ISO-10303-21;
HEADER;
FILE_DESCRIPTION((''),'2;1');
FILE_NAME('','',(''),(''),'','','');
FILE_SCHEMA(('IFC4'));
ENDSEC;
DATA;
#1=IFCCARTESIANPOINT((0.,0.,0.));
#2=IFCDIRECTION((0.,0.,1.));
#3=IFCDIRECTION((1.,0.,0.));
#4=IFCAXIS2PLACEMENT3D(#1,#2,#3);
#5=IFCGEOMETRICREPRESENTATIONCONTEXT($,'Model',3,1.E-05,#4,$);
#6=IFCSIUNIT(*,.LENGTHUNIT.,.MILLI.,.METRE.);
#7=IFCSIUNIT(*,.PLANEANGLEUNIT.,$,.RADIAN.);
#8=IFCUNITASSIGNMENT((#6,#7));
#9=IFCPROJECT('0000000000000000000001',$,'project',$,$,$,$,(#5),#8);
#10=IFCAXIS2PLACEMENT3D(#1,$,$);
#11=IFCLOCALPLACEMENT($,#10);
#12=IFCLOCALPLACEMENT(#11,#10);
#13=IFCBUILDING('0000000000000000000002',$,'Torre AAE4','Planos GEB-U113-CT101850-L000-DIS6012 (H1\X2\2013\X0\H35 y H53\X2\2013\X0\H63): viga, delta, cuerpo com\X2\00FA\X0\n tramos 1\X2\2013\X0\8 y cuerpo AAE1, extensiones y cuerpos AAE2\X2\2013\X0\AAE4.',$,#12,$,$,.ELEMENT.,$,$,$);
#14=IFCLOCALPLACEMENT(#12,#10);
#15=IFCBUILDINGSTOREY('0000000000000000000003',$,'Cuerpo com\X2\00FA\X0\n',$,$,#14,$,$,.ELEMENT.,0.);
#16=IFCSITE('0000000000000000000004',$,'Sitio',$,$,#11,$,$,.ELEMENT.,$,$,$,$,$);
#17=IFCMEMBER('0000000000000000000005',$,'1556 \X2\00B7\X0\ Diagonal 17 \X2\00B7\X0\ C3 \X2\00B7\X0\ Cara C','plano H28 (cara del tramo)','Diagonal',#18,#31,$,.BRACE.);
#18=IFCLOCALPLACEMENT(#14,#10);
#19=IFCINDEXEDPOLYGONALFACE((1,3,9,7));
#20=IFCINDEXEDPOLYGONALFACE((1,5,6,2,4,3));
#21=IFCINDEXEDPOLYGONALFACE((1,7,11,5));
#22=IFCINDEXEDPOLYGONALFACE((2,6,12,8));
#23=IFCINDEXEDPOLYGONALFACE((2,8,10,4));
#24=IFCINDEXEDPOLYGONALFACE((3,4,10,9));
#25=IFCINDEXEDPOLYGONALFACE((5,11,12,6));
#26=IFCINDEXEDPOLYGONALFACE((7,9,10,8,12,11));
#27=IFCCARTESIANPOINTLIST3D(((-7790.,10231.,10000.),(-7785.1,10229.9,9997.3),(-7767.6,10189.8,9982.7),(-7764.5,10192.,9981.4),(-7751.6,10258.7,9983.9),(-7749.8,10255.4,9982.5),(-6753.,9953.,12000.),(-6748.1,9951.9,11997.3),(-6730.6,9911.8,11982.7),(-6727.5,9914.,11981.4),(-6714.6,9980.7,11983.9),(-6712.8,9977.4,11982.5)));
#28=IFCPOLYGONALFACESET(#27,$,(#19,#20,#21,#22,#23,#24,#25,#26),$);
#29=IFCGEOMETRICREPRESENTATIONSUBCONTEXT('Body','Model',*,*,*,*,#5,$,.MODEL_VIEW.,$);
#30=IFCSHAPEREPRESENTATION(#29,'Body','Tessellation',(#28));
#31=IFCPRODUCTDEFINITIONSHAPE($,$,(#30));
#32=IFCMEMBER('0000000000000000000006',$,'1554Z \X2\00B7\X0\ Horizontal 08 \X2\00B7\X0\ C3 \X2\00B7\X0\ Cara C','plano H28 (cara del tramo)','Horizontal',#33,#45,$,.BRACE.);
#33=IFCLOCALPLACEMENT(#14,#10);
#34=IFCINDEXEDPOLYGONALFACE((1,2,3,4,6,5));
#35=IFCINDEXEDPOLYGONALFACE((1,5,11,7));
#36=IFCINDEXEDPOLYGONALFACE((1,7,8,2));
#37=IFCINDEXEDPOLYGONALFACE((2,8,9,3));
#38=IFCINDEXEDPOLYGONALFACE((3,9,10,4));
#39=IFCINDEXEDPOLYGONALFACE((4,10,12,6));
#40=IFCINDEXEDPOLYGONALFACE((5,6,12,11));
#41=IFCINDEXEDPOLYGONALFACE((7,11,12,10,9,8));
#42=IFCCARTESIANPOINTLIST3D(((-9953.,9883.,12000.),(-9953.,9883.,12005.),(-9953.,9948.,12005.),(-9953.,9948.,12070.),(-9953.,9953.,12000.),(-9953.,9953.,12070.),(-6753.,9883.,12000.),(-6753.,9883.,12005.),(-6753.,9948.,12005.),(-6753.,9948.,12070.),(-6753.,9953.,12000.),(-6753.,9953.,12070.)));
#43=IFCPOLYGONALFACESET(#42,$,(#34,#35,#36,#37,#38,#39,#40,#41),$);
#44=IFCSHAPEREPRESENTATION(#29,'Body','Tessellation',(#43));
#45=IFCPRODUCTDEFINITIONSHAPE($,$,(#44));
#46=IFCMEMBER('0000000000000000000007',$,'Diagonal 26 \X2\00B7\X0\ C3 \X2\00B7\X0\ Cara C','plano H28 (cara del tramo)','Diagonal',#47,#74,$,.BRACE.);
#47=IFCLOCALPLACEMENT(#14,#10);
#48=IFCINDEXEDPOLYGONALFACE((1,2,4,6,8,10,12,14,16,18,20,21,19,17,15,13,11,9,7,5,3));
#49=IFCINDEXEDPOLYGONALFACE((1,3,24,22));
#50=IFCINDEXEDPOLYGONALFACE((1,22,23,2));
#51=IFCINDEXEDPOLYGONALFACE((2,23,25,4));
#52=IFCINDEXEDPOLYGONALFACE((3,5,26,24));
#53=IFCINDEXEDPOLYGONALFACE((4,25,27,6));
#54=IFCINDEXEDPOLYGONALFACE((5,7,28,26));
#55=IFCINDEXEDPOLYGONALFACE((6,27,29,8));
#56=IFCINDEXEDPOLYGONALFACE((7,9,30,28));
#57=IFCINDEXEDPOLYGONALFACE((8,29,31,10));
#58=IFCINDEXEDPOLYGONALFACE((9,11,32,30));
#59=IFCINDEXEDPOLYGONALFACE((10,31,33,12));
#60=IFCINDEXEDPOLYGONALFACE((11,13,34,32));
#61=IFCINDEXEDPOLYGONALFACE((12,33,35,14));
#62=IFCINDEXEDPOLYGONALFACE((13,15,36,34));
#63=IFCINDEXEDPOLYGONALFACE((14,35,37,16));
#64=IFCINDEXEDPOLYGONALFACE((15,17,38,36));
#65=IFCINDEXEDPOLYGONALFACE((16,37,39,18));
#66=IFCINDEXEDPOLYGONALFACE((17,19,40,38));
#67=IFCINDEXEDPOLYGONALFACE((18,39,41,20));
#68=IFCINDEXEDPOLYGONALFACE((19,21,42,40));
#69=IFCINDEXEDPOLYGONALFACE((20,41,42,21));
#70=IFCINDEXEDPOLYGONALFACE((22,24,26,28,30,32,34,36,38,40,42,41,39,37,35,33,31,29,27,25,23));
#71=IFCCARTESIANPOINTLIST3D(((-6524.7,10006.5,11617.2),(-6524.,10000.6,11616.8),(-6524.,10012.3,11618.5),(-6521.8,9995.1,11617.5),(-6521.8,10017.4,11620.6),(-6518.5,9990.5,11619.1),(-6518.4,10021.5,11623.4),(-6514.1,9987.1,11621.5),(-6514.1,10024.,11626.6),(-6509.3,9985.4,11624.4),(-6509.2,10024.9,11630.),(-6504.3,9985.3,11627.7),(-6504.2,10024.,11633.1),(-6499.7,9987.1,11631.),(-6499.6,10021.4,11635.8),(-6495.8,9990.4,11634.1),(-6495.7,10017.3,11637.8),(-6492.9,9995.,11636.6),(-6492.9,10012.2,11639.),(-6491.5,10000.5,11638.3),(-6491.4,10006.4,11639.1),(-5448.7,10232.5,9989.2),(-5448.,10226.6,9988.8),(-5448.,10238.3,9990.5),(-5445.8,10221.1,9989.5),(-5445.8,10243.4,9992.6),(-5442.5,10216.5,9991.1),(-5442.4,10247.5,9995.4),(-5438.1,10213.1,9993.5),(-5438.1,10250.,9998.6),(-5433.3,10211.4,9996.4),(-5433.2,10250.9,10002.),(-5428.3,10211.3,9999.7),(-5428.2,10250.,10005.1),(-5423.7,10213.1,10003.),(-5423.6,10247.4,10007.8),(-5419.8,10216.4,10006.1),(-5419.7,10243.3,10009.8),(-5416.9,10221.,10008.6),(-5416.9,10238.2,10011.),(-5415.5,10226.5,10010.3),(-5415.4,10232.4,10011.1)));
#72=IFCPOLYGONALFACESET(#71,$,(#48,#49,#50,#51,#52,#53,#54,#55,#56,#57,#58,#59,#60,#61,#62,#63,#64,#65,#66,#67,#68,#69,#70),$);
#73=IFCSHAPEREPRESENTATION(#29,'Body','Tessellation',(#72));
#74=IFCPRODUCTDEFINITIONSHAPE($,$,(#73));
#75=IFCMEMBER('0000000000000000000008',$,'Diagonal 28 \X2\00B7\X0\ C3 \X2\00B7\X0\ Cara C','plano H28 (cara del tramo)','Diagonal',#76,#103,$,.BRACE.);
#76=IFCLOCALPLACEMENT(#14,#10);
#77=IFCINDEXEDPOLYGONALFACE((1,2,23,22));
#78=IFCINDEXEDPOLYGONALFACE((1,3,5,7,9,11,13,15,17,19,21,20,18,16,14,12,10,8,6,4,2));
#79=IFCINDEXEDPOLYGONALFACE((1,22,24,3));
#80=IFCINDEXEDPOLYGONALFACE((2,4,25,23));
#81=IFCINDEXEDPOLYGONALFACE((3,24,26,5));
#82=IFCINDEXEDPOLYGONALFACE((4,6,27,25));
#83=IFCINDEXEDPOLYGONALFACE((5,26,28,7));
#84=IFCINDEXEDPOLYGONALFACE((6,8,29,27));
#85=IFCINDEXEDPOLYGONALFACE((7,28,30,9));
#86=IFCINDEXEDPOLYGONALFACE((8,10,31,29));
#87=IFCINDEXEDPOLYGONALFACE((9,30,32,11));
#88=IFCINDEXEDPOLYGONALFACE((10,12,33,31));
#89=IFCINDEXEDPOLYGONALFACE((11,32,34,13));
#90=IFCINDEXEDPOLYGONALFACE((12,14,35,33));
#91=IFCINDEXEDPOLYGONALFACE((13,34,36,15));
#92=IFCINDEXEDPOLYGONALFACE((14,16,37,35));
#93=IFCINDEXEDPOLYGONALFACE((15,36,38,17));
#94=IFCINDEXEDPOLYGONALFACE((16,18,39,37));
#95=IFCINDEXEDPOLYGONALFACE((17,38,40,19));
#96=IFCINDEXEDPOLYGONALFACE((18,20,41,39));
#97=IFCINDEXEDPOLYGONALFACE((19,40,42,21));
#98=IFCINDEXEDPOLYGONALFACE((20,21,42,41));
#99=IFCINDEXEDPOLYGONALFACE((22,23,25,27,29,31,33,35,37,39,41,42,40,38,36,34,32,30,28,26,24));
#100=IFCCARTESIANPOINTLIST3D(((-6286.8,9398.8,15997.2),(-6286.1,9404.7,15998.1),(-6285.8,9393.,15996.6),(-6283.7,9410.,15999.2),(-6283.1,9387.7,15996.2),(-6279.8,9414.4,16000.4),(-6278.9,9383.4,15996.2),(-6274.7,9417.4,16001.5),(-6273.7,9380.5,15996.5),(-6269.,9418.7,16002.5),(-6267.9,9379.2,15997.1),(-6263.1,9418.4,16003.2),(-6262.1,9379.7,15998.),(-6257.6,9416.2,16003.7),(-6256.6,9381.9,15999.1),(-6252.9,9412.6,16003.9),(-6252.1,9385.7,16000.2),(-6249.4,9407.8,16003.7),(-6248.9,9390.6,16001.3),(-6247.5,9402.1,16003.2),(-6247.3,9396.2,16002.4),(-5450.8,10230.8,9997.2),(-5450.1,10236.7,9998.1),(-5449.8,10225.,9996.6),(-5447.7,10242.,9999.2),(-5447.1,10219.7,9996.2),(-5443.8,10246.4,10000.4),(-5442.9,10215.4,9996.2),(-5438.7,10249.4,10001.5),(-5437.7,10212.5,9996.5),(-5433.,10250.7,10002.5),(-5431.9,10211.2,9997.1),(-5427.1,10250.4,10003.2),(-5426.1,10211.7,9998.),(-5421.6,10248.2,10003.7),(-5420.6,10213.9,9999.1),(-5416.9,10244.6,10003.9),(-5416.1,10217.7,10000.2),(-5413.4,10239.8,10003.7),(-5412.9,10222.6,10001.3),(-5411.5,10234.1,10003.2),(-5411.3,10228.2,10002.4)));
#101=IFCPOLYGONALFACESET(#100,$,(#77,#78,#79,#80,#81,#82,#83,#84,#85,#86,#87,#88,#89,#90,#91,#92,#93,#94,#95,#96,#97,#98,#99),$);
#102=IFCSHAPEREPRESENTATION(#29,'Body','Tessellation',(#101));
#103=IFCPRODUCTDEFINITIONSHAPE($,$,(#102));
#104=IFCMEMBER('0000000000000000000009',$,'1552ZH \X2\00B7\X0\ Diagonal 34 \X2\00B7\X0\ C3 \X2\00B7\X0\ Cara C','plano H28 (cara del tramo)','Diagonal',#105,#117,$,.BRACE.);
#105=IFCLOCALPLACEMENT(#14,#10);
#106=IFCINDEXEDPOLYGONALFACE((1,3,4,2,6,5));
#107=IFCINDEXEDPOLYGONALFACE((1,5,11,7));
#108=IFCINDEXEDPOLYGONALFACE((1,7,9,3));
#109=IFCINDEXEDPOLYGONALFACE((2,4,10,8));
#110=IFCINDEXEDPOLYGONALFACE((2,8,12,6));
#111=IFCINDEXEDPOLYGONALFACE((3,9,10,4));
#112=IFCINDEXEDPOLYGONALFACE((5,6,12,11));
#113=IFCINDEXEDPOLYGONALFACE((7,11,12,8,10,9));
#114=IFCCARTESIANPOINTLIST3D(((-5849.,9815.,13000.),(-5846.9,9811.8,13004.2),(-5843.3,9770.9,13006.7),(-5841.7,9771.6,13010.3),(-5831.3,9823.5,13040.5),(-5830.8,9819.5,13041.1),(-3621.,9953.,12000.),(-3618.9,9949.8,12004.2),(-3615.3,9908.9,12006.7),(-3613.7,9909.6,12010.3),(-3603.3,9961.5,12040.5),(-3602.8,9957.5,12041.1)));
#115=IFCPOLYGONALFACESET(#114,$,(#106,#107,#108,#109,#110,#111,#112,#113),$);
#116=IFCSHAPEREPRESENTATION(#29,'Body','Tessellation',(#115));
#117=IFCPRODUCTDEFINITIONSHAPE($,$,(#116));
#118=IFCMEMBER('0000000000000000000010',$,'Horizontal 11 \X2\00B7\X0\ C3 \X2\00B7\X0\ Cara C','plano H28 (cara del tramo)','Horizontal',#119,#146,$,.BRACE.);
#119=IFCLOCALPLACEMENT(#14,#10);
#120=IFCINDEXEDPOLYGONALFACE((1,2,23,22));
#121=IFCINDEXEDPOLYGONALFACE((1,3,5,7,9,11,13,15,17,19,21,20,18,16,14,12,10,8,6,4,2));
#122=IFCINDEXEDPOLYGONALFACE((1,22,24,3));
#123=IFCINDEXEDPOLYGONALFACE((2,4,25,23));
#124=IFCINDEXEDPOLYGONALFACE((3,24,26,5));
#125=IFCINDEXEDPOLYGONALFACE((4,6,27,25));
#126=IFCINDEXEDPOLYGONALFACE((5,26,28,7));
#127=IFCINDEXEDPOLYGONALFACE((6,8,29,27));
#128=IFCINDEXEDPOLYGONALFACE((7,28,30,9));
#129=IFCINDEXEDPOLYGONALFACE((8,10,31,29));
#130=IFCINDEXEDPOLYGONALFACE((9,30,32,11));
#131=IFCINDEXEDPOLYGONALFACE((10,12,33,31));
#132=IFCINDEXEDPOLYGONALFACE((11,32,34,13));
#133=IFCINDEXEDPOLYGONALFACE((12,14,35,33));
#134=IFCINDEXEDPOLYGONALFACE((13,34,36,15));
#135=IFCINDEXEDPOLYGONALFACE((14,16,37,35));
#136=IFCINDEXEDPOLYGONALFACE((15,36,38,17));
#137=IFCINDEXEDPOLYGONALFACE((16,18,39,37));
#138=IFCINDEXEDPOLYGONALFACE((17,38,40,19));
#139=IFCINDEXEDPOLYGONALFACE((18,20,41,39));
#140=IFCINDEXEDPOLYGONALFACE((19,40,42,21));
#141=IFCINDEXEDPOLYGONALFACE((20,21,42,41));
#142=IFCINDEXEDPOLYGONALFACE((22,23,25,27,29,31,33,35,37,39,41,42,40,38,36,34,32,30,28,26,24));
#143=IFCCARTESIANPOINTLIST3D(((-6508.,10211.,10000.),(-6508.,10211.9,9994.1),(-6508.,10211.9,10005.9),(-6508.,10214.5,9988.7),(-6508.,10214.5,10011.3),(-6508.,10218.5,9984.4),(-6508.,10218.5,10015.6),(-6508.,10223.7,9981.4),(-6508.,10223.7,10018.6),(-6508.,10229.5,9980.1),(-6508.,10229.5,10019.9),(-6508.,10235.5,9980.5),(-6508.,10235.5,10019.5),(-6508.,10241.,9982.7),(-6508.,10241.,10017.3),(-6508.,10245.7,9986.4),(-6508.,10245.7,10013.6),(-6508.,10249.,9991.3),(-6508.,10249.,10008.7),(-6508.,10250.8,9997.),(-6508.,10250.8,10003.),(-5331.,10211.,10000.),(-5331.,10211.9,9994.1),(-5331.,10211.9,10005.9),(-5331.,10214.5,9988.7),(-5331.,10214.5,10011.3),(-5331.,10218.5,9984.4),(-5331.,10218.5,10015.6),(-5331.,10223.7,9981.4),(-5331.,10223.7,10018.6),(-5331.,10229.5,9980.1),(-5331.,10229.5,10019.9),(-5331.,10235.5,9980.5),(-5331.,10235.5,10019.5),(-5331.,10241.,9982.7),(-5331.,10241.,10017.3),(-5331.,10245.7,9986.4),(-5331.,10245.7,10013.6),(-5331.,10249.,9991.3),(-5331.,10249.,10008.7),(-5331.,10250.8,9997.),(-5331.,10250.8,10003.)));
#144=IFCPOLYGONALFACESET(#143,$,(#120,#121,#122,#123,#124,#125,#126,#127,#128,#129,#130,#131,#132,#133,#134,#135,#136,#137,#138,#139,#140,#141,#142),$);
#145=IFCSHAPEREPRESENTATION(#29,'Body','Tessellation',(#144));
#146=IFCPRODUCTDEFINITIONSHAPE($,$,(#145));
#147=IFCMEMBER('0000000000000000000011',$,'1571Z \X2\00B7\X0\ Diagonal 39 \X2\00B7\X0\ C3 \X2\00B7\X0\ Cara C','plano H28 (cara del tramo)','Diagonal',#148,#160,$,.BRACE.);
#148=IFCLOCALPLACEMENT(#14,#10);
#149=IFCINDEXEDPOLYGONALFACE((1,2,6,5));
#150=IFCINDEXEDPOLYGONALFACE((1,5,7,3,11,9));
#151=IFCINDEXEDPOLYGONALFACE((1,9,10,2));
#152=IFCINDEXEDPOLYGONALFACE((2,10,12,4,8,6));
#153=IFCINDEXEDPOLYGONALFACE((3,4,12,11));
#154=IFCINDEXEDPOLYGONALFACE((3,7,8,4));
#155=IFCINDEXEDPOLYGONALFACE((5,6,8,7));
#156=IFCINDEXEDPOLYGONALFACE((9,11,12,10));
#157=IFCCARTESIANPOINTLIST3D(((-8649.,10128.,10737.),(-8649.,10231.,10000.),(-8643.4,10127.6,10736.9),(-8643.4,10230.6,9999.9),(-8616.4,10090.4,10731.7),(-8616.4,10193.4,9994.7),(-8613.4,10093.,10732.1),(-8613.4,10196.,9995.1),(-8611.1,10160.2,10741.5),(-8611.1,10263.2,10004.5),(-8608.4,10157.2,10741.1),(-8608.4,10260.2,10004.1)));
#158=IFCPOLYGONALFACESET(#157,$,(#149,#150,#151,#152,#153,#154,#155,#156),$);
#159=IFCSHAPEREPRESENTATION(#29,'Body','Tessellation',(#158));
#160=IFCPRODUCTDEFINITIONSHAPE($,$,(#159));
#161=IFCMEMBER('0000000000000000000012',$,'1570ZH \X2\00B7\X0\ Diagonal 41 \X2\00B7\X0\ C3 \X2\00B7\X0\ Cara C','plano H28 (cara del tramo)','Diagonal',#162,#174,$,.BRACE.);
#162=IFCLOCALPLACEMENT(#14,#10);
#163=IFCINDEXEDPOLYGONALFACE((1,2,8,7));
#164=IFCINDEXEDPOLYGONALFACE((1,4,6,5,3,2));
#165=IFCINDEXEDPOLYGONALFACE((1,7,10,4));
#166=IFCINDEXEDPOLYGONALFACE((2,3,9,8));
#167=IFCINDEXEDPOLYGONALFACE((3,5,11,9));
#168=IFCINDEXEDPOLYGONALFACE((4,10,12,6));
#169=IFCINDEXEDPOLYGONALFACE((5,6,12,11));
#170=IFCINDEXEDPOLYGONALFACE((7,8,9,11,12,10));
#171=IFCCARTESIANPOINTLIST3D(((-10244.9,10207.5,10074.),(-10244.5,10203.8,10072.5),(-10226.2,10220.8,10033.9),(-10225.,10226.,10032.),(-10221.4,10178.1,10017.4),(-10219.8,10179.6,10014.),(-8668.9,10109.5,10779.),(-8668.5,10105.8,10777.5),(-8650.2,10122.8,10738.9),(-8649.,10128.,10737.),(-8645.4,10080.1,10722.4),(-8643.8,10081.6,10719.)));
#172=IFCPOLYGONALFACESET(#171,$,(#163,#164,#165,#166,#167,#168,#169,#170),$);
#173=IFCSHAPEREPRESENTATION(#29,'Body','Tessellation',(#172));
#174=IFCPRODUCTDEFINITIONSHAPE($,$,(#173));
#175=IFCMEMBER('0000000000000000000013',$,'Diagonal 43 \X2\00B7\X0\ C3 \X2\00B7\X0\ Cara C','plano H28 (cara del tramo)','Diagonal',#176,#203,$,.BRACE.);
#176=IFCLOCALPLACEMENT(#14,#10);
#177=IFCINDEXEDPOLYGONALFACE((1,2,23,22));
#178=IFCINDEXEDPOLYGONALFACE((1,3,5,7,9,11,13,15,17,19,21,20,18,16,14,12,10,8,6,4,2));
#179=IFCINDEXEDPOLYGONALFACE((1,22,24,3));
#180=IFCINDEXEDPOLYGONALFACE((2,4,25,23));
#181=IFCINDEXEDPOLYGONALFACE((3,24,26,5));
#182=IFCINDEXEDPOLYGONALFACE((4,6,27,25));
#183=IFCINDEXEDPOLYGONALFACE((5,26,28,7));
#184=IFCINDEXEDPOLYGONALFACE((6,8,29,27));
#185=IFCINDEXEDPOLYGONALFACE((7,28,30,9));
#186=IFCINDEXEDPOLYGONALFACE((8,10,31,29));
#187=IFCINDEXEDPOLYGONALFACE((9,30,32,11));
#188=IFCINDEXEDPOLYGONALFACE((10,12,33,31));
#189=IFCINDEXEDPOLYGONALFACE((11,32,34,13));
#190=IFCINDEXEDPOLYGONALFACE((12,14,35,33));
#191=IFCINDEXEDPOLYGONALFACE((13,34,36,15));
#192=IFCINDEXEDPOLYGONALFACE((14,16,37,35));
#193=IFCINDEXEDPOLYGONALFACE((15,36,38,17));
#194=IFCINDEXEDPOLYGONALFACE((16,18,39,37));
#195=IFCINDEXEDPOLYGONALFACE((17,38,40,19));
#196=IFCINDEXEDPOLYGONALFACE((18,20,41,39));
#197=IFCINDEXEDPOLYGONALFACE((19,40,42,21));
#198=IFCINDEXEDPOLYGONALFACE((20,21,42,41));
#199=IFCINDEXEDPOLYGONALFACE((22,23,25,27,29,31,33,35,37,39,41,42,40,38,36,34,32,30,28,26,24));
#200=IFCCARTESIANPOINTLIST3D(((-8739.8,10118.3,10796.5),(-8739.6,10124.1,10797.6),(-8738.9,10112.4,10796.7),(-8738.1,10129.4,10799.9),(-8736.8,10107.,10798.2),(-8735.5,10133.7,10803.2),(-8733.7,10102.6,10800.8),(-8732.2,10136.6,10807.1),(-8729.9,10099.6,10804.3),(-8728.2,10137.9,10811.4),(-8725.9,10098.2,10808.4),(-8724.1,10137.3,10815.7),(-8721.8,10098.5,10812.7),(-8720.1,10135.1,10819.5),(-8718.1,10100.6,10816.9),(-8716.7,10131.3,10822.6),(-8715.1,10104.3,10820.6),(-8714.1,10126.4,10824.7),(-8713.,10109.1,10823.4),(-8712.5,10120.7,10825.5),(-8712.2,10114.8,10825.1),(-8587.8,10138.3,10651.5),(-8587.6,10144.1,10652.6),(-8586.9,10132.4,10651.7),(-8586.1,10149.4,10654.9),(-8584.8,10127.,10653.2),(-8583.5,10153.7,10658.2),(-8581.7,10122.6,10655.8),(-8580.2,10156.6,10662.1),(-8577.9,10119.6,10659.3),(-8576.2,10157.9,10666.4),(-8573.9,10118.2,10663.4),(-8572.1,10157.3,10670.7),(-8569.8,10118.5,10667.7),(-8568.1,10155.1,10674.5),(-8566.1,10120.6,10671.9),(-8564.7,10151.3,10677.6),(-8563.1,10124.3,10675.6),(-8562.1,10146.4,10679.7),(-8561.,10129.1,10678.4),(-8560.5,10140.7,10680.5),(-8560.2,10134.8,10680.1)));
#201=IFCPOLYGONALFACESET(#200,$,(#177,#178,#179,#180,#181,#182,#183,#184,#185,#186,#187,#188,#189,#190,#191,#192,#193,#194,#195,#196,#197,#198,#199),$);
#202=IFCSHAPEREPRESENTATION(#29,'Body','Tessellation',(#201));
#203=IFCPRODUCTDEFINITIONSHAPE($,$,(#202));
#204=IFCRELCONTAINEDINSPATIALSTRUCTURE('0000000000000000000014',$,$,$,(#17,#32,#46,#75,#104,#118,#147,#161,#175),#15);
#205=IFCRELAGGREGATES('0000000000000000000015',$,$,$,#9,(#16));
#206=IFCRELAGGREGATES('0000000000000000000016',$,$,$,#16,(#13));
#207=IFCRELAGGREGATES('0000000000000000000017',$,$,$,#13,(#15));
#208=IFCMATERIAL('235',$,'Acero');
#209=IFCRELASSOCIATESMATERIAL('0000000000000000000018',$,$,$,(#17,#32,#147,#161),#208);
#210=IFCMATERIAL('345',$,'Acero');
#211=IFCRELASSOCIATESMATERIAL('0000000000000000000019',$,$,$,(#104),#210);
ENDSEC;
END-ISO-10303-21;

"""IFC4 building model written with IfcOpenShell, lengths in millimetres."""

from ifc_helpers import new_model, si_unit, frame, frame_2d, origin, origin_with_axes, place, context, subcontext, project, spatial, circle, l_section, extrude, material, element, save


model = new_model("IFC4")

# Units and contexts
model_context = context("Model", 3, precision=1e-05, world=origin_with_axes())
body_context = subcontext(model_context, "Body", "Model", "MODEL_VIEW")
ifc_project = project(units=[si_unit("LENGTHUNIT", "METRE", prefix="MILLI"), si_unit("PLANEANGLEUNIT", "RADIAN")], contexts=[model_context])

# Site, building, storey
site_placement = place(None, origin())
site = spatial("IfcSite", under=ifc_project, at=site_placement, Name="Sitio", CompositionType="ELEMENT")
building_placement = place(site_placement, origin())
building = spatial("IfcBuilding", under=site, at=building_placement, Name="Torre AAE4", Description="Planos GEB-U113-CT101850-L000-DIS6012 (H1–H35 y H53–H63): viga, delta, cuerpo común tramos 1–8 y cuerpo AAE1, extensiones y cuerpos AAE2–AAE4.", CompositionType="ELEMENT")
storey_placement = place(building_placement, origin())
storey = spatial("IfcBuildingStorey", under=building, at=storey_placement, Name="Cuerpo común", CompositionType="ELEMENT", Elevation=0.0)

# Members
ifc_material_1 = material(Name="235", Category="Acero")
ifc_material_2 = material(Name="345", Category="Acero")
member_1_placement = place(storey_placement, frame((-7790.0, 10231.0, 10000.0), z_axis=(0.456839, -0.12247, 0.881078), x_axis=(0.448371, -0.823752, -0.346982)))
element("IfcMember", 1, at=member_1_placement, inside=storey, material=ifc_material_1, Name="1556 · Diagonal 17 · C3 · Cara C", Description="plano H28 (cara del tramo)", ObjectType="Diagonal", PredefinedType="BRACE", context=body_context, shape_type="SweptSolid", body=[
    extrude(l_section(Depth=50.0, Width=50.0, Thickness=4.0, at=frame_2d((25.0, 25.0))), None, (0.0, 0.0, 1.0), 2269.9),
])
member_2_placement = place(storey_placement, frame((-6753.0, 9953.0, 12000.0), z_axis=(-1.0, 0.0, 0.0), x_axis=(0.0, -1.0, 0.0)))
element("IfcMember", 2, at=member_2_placement, inside=storey, material=ifc_material_1, Name="1554Z · Horizontal 08 · C3 · Cara C", Description="plano H28 (cara del tramo)", ObjectType="Horizontal", PredefinedType="BRACE", context=body_context, shape_type="SweptSolid", body=[
    extrude(l_section(Depth=70.0, Width=70.0, Thickness=5.0, at=frame_2d((35.0, 35.0))), None, (0.0, 0.0, 1.0), 3200.0),
])
member_3_placement = place(storey_placement, frame((-6508.0, 10005.0, 11628.0), z_axis=(0.547724, 0.115042, -0.828712), x_axis=(0.41674, -0.896397, 0.150999)))
element("IfcMember", 3, at=member_3_placement, inside=storey, Name="Diagonal 26 · C3 · Cara C", Description="plano H28 (cara del tramo)", ObjectType="Diagonal", PredefinedType="BRACE", context=body_context, shape_type="SweptSolid", body=[
    extrude(circle(Radius=20.0), None, (0.0, 0.0, 1.0), 1964.5),
])
member_4_placement = place(storey_placement, frame((-5431.0, 10231.0, 10000.0), z_axis=(-0.136717, -0.136063, 0.981221), x_axis=(0.518901, -0.853592, -0.046065)))
element("IfcMember", 4, at=member_4_placement, inside=storey, Name="Diagonal 28 · C3 · Cara C", Description="plano H28 (cara del tramo)", ObjectType="Diagonal", PredefinedType="BRACE", context=body_context, shape_type="SweptSolid", body=[
    extrude(circle(Radius=20.0), None, (0.0, 0.0, 1.0), 6114.8),
])
member_5_placement = place(storey_placement, frame((-3621.0, 9953.0, 12000.0), z_axis=(-0.910866, -0.056418, 0.408827), x_axis=(0.12766, -0.980545, 0.149111)))
element("IfcMember", 5, at=member_5_placement, inside=storey, material=ifc_material_2, Name="1552ZH · Diagonal 34 · C3 · Cara C", Description="plano H28 (cara del tramo)", ObjectType="Diagonal", PredefinedType="BRACE", context=body_context, shape_type="SweptSolid", body=[
    extrude(l_section(Depth=45.0, Width=45.0, Thickness=4.0, at=frame_2d((22.5, 22.5))), None, (0.0, 0.0, 1.0), 2446.0),
])
member_6_placement = place(storey_placement, frame((-6508.0, 10231.0, 10000.0), z_axis=(1.0, 0.0, 0.0), x_axis=(0.0, -1.0, 0.0)))
element("IfcMember", 6, at=member_6_placement, inside=storey, Name="Horizontal 11 · C3 · Cara C", Description="plano H28 (cara del tramo)", ObjectType="Horizontal", PredefinedType="BRACE", context=body_context, shape_type="SweptSolid", body=[
    extrude(circle(Radius=20.0), None, (0.0, 0.0, 1.0), 1177.0),
])
member_7_placement = place(storey_placement, frame((-8649.0, 10231.0, 10000.0), z_axis=(0.0, -0.138411, 0.990375), x_axis=(0.651125, -0.751665, -0.10505)))
element("IfcMember", 7, at=member_7_placement, inside=storey, material=ifc_material_1, Name="1571Z · Diagonal 39 · C3 · Cara C", Description="plano H28 (cara del tramo)", ObjectType="Diagonal", PredefinedType="BRACE", context=body_context, shape_type="SweptSolid", body=[
    extrude(l_section(Depth=50.0, Width=50.0, Thickness=4.0, at=frame_2d((25.0, 25.0))), None, (0.0, 0.0, 1.0), 744.2),
])
member_8_placement = place(storey_placement, frame((-8649.0, 10128.0, 10737.0), z_axis=(-0.911363, 0.056671, -0.407684), x_axis=(0.103073, -0.927495, -0.359344)))
element("IfcMember", 8, at=member_8_placement, inside=storey, material=ifc_material_1, Name="1570ZH · Diagonal 41 · C3 · Cara C", Description="plano H28 (cara del tramo)", ObjectType="Diagonal", PredefinedType="BRACE", context=body_context, shape_type="SweptSolid", body=[
    extrude(l_section(Depth=50.0, Width=50.0, Thickness=4.0, at=frame_2d((25.0, 25.0))), None, (0.0, 0.0, 1.0), 1729.3),
])
member_9_placement = place(storey_placement, frame((-8574.0, 10138.0, 10666.0), z_axis=(-0.720314, -0.094778, 0.687142), x_axis=(0.396782, -0.868845, 0.296096)))
element("IfcMember", 9, at=member_9_placement, inside=storey, Name="Diagonal 43 · C3 · Cara C", Description="plano H28 (cara del tramo)", ObjectType="Diagonal", PredefinedType="BRACE", context=body_context, shape_type="SweptSolid", body=[
    extrude(circle(Radius=20.0), None, (0.0, 0.0, 1.0), 211.0),
])

save(model, "model.ifc")
